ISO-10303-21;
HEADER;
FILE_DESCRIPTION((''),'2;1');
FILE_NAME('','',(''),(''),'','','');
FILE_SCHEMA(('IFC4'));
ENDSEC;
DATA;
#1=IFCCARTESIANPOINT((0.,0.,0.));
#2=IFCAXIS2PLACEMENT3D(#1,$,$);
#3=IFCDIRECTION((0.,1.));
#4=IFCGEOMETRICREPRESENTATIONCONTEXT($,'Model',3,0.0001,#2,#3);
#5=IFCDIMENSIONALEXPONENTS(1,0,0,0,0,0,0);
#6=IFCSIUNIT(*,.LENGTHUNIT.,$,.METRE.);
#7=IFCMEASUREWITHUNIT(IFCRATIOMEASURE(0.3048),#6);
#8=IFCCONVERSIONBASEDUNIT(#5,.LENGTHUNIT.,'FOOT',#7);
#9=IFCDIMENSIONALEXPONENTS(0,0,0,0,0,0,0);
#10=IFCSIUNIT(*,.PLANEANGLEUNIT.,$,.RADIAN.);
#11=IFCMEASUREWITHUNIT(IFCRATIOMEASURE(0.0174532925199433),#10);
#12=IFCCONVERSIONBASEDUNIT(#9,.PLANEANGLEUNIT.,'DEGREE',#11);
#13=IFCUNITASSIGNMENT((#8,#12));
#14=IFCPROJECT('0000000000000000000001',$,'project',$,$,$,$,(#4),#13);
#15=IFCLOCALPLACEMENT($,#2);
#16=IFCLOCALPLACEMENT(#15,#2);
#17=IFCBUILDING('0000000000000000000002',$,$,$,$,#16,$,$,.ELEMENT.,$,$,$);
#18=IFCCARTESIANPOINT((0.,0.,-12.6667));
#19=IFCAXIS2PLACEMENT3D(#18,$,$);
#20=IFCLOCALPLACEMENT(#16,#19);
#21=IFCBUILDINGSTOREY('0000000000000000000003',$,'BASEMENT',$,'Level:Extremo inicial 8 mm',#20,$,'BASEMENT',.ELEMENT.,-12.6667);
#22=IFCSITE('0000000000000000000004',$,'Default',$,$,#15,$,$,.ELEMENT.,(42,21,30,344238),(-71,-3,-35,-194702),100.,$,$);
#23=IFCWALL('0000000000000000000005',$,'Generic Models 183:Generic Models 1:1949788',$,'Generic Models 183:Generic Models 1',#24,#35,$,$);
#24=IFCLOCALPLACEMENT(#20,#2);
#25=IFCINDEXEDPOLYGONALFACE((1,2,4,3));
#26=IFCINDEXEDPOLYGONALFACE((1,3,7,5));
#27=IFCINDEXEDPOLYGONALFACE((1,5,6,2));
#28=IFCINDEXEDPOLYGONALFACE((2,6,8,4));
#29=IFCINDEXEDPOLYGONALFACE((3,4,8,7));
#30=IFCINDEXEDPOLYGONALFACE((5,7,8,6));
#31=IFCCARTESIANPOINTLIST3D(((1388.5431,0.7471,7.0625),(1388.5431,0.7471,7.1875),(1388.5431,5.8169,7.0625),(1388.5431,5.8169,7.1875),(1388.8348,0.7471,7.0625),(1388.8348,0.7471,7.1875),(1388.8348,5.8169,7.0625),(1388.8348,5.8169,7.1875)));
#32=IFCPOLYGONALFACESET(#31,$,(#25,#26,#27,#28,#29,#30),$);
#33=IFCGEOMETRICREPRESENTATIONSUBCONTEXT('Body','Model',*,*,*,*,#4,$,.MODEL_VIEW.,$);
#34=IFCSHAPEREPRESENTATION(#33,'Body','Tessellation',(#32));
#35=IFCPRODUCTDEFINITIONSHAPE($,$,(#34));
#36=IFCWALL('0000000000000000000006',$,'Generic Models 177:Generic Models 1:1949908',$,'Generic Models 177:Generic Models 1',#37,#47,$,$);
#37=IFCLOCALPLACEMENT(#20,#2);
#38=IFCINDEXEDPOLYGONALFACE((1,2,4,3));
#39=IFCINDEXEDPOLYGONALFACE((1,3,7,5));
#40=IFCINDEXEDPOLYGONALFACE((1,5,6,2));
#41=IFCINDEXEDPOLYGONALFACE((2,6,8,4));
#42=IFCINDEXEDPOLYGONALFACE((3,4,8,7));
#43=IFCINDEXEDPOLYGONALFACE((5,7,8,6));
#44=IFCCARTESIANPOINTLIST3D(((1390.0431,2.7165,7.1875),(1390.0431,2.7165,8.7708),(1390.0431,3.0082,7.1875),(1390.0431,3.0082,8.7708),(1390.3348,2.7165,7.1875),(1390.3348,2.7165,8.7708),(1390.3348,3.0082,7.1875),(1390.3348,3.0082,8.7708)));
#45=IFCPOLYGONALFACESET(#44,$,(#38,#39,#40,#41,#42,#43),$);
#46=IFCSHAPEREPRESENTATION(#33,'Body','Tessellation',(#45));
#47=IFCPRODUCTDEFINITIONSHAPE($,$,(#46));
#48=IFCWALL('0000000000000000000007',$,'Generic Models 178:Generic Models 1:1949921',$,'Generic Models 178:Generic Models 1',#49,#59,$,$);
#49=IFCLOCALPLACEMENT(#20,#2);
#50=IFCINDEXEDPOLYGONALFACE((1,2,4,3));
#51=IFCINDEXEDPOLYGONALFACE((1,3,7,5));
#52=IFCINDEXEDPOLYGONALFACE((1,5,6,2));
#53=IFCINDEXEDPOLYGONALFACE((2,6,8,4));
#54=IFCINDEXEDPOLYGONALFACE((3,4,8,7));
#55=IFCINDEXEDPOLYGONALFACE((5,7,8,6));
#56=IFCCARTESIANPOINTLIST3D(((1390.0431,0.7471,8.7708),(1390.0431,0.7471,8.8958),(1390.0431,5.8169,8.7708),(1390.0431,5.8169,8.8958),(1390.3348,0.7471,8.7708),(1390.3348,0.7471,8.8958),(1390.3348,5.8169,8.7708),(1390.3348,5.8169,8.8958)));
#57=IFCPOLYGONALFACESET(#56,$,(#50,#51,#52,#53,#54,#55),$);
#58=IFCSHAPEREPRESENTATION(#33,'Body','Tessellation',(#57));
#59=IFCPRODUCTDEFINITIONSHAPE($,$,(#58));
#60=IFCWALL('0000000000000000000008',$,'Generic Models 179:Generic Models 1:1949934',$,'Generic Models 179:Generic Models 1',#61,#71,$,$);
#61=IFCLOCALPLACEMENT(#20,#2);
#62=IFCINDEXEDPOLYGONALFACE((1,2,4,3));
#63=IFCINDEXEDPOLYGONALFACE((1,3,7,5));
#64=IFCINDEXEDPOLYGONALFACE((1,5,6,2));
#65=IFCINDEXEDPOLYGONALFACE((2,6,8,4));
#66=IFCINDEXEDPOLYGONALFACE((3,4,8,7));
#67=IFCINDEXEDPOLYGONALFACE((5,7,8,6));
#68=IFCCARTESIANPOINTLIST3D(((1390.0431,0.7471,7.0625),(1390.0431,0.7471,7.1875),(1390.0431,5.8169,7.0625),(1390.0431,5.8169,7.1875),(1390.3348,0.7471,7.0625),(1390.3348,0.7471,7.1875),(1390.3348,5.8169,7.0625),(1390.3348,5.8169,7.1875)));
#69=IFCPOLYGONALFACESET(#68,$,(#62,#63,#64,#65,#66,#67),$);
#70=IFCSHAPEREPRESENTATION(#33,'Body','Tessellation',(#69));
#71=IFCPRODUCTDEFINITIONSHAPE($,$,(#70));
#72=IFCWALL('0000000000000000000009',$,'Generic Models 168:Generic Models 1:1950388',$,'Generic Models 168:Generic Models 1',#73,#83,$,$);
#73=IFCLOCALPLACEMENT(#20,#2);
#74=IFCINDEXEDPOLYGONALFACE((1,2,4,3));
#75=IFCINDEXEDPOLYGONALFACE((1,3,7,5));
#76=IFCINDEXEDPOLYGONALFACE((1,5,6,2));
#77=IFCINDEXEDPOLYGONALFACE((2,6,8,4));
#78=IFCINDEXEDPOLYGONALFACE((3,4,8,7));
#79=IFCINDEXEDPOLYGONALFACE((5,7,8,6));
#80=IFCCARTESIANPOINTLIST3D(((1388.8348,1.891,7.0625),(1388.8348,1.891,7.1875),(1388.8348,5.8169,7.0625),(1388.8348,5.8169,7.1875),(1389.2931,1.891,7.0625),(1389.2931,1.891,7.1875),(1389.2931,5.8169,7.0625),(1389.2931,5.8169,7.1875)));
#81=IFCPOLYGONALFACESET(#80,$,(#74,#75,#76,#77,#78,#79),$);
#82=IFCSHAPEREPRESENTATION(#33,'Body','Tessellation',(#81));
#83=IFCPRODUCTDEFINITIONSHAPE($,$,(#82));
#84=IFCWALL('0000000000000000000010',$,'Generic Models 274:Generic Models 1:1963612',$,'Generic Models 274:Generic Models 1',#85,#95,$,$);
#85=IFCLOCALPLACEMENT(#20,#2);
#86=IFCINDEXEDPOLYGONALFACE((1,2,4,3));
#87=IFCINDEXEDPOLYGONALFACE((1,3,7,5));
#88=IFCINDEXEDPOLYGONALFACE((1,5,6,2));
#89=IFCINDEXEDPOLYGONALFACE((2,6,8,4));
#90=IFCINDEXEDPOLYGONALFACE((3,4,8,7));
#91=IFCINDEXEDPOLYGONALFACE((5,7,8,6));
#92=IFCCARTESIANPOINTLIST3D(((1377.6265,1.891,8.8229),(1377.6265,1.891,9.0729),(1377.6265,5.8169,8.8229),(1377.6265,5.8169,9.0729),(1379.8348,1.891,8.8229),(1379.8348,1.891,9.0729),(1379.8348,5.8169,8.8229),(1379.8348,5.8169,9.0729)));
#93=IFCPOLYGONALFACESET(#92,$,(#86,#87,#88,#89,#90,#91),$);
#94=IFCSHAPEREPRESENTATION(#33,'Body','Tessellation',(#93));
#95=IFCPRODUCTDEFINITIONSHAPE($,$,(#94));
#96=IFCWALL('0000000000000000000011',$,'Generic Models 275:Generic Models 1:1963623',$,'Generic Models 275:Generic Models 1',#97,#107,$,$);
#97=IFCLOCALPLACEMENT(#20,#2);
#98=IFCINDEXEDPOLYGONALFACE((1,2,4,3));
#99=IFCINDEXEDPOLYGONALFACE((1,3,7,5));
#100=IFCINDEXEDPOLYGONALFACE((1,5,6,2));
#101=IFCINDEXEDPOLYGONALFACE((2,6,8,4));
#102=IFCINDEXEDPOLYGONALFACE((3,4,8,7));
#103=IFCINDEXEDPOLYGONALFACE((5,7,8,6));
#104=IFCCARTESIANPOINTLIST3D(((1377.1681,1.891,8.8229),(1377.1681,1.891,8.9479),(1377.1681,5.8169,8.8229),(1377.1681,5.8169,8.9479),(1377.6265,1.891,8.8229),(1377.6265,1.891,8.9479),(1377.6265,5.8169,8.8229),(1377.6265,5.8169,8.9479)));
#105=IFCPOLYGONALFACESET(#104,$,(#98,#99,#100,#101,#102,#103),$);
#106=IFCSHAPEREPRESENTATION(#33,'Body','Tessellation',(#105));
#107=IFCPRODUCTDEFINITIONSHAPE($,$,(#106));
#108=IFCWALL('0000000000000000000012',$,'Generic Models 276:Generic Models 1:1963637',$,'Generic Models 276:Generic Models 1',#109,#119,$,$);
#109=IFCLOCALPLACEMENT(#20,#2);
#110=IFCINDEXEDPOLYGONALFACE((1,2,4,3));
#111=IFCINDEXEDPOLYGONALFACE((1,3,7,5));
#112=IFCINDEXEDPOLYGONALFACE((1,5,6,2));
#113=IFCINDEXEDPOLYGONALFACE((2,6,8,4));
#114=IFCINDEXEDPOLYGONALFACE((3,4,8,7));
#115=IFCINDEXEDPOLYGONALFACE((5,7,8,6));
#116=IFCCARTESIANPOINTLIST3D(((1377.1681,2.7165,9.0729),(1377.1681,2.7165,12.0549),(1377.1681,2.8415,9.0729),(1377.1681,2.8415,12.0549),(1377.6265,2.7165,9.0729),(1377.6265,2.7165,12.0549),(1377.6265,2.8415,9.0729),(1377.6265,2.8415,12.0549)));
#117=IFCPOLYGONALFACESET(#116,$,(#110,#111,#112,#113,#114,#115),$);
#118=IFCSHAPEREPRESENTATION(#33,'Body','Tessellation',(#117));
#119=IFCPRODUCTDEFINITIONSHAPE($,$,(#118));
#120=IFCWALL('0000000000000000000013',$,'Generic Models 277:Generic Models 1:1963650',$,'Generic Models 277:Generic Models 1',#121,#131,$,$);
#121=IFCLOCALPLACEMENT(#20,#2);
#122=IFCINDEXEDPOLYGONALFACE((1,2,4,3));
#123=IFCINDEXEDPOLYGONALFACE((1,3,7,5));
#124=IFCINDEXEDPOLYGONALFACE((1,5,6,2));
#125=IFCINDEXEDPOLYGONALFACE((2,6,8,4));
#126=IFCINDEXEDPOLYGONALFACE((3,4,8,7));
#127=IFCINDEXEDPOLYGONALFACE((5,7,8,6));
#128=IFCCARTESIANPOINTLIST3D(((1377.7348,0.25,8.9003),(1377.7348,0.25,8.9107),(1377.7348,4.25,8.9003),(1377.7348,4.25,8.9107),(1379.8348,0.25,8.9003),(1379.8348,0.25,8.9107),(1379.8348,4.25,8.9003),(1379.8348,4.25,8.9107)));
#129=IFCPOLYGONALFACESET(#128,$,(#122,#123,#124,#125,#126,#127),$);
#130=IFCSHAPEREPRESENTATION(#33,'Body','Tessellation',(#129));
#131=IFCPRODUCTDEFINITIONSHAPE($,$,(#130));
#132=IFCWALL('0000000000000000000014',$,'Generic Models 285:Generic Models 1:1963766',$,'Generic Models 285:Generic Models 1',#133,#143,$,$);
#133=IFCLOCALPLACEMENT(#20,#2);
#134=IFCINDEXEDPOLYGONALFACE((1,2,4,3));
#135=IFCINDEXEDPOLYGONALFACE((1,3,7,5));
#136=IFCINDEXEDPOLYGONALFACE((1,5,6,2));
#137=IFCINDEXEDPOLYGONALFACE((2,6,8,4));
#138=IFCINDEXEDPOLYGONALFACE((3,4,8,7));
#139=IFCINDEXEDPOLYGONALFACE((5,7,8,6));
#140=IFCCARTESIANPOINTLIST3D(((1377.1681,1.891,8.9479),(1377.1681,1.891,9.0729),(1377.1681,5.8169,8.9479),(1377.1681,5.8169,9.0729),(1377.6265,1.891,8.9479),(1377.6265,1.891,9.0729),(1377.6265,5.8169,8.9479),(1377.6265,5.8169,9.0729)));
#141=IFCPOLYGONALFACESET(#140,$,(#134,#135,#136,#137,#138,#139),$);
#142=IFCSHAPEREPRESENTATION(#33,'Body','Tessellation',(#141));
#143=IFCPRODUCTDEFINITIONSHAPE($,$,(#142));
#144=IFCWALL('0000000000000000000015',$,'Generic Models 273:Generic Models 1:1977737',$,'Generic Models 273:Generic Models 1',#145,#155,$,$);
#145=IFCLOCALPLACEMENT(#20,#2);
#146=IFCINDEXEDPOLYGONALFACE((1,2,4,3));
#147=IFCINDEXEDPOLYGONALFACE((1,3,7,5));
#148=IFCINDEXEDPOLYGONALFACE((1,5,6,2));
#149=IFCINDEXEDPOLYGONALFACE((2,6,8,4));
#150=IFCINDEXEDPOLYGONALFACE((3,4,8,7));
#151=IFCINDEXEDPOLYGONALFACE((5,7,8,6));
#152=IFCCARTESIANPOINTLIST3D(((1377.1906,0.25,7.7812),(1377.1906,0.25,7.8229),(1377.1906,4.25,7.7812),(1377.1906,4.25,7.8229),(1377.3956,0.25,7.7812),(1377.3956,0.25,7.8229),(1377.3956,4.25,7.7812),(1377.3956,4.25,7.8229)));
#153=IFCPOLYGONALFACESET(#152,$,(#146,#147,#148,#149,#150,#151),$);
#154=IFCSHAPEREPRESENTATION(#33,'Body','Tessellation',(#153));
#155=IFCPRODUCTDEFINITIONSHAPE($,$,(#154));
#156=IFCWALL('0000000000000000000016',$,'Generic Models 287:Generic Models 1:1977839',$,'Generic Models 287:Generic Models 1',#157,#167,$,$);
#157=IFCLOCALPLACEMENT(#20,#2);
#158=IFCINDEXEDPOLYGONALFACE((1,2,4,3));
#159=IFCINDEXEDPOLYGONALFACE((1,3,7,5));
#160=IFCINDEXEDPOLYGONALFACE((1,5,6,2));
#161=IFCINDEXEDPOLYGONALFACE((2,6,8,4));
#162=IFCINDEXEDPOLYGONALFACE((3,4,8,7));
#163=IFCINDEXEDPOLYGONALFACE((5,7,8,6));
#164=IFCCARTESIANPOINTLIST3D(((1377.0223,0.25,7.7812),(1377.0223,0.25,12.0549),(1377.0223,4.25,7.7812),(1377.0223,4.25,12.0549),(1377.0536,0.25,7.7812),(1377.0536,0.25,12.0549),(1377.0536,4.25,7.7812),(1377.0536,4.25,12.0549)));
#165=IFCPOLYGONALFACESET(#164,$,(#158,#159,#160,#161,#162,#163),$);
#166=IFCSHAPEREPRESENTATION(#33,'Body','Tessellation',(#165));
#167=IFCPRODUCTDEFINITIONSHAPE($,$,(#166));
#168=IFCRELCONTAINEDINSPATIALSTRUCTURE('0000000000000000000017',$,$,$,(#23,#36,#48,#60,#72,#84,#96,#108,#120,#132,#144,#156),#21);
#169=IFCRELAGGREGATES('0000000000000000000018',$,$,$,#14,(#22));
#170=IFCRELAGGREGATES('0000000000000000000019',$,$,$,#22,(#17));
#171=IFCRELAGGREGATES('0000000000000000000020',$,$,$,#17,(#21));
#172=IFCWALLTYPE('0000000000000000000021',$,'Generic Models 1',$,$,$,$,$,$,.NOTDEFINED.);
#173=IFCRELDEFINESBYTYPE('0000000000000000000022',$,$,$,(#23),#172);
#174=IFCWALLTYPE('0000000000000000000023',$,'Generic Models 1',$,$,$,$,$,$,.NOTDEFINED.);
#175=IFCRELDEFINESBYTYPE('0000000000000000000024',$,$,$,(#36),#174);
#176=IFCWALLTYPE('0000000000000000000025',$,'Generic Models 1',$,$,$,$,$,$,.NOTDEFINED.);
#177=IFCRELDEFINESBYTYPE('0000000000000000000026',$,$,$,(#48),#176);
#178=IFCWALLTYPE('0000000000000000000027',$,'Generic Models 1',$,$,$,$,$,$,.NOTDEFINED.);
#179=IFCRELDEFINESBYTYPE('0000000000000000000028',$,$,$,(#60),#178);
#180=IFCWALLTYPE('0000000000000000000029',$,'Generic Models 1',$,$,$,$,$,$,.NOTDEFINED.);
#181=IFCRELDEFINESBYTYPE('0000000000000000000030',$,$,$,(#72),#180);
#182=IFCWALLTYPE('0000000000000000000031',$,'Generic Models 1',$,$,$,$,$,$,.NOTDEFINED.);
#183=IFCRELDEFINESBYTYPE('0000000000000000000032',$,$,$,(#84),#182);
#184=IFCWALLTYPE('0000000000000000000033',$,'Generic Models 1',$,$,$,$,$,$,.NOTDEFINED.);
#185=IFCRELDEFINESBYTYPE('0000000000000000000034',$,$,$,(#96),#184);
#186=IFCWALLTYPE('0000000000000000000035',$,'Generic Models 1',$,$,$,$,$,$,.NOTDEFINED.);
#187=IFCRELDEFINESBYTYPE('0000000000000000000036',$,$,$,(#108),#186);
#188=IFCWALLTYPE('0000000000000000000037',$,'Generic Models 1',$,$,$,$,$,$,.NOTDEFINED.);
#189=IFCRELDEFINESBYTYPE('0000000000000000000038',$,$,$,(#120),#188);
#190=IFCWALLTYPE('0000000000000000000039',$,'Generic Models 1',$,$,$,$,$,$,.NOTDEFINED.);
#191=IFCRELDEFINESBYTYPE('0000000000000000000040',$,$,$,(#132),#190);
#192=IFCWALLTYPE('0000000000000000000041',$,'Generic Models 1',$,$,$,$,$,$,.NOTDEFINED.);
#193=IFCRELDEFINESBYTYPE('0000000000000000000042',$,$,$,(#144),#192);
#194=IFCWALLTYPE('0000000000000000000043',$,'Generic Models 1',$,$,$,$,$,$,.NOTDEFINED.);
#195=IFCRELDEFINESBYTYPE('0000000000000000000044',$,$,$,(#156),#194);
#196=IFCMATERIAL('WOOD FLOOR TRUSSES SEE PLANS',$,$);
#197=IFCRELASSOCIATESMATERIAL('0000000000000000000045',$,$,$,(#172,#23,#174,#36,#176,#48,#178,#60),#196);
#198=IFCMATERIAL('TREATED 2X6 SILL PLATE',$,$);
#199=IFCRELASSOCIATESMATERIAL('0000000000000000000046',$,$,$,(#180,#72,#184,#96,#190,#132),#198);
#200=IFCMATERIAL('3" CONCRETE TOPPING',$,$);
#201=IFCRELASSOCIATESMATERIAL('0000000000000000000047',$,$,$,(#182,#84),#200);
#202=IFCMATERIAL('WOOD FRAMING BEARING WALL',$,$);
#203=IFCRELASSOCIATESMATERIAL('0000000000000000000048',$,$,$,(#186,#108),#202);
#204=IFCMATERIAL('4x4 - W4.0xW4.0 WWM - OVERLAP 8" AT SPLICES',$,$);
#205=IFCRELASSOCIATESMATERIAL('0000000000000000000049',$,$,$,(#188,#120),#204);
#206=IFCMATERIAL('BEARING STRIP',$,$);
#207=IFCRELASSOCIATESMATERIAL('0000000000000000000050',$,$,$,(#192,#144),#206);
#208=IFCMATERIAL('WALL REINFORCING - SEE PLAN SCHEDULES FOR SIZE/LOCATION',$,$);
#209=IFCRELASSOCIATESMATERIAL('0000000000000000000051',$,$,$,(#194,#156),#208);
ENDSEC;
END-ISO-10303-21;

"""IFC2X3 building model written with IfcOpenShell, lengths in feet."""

from ifc_helpers import new_model, entity, si_unit, converted_unit, direction, frame, frame_2d, origin, place, context, subcontext, project, spatial, rectangle, extrude, material, type_object, element, save


model = new_model("IFC2X3")

# Units and contexts
model_context = context("Model", 3, precision=0.0001, world=origin(), true_north=direction((0.0, 1.0)))
body_context = subcontext(model_context, "Body", "Model", "MODEL_VIEW")
ifc_project = project(units=[converted_unit("LENGTHUNIT", "FOOT", entity("IfcRatioMeasure", 0.3048), si_unit("LENGTHUNIT", "METRE"), dimensions=[1, 0, 0, 0, 0, 0, 0]), converted_unit("PLANEANGLEUNIT", "DEGREE", entity("IfcRatioMeasure", 0.0174532925199433), si_unit("PLANEANGLEUNIT", "RADIAN"), dimensions=[0, 0, 0, 0, 0, 0, 0])], contexts=[model_context])

# Site, building, storey
site_placement = place(None, origin())
site = spatial("IfcSite", under=ifc_project, at=site_placement, Name="Default", CompositionType="ELEMENT", RefLatitude=(42, 21, 30, 344238), RefLongitude=(-71, -3, -35, -194702), RefElevation=100.0)
building_placement = place(site_placement, origin())
building = spatial("IfcBuilding", under=site, at=building_placement, CompositionType="ELEMENT")
storey_placement = place(building_placement, frame((0.0, 0.0, -12.6667)))
storey = spatial("IfcBuildingStorey", under=building, at=storey_placement, Name="BASEMENT", ObjectType="Level:Extremo inicial 8 mm", LongName="BASEMENT", CompositionType="ELEMENT", Elevation=-12.6667)

# Walls
ifc_material_1 = material(Name="BEARING STRIP")
ifc_material_2 = material(Name="WOOD FLOOR TRUSSES SEE PLANS")
ifc_material_3 = material(Name="3\" CONCRETE TOPPING")
ifc_material_4 = material(Name="4x4 - W4.0xW4.0 WWM - OVERLAP 8\" AT SPLICES")
wall_type_1 = type_object("IfcWallType", Name="Generic Models 1", PredefinedType="NOTDEFINED", material=ifc_material_2)
wall_1_placement = place(storey_placement, frame((1388.5431, 0.7471, 7.0625), z_axis=(0.0, 0.0, 1.0), x_axis=(0.0, 1.0, 0.0)))
element("IfcWall", 1, at=wall_1_placement, inside=storey, type_object=wall_type_1, material=ifc_material_2, Name="Generic Models 183:Generic Models 1:1949788", ObjectType="Generic Models 183:Generic Models 1", context=body_context, shape_type="SweptSolid", body=[
    extrude(rectangle(XDim=5.0697, YDim=0.2917, at=frame_2d((0.0, 0.0), x_axis=(1.0, 0.0))), frame((2.5349, -0.1458, 0.0)), (0.0, 0.0, 1.0), 0.125),
])
wall_type_2 = type_object("IfcWallType", Name="Generic Models 1", PredefinedType="NOTDEFINED", material=ifc_material_2)
wall_2_placement = place(storey_placement, frame((1390.0431, 2.7165, 7.1875)))
element("IfcWall", 2, at=wall_2_placement, inside=storey, type_object=wall_type_2, material=ifc_material_2, Name="Generic Models 177:Generic Models 1:1949908", ObjectType="Generic Models 177:Generic Models 1", context=body_context, shape_type="SweptSolid", body=[
    extrude(rectangle(XDim=0.2917, YDim=0.2917, at=frame_2d((0.0, 0.0), x_axis=(1.0, 0.0))), frame((0.1458, 0.1458, 0.0), z_axis=(0.0, 0.0, 1.0), x_axis=(0.0, 1.0, 0.0)), (0.0, 0.0, 1.0), 1.5833),
])
wall_type_3 = type_object("IfcWallType", Name="Generic Models 1", PredefinedType="NOTDEFINED", material=ifc_material_2)
wall_3_placement = place(storey_placement, frame((1390.0431, 0.7471, 8.7708), z_axis=(0.0, 0.0, 1.0), x_axis=(0.0, 1.0, 0.0)))
element("IfcWall", 3, at=wall_3_placement, inside=storey, type_object=wall_type_3, material=ifc_material_2, Name="Generic Models 178:Generic Models 1:1949921", ObjectType="Generic Models 178:Generic Models 1", context=body_context, shape_type="SweptSolid", body=[
    extrude(rectangle(XDim=5.0697, YDim=0.2917, at=frame_2d((0.0, 0.0), x_axis=(1.0, 0.0))), frame((2.5349, -0.1458, 0.0)), (0.0, 0.0, 1.0), 0.125),
])
wall_type_4 = type_object("IfcWallType", Name="Generic Models 1", PredefinedType="NOTDEFINED", material=ifc_material_2)
wall_4_placement = place(storey_placement, frame((1390.0431, 0.7471, 7.0625), z_axis=(0.0, 0.0, 1.0), x_axis=(0.0, 1.0, 0.0)))
element("IfcWall", 4, at=wall_4_placement, inside=storey, type_object=wall_type_4, material=ifc_material_2, Name="Generic Models 179:Generic Models 1:1949934", ObjectType="Generic Models 179:Generic Models 1", context=body_context, shape_type="SweptSolid", body=[
    extrude(rectangle(XDim=5.0697, YDim=0.2917, at=frame_2d((0.0, 0.0), x_axis=(1.0, 0.0))), frame((2.5349, -0.1458, 0.0)), (0.0, 0.0, 1.0), 0.125),
])
ifc_material_5 = material(Name="TREATED 2X6 SILL PLATE")
wall_type_5 = type_object("IfcWallType", Name="Generic Models 1", PredefinedType="NOTDEFINED", material=ifc_material_5)
wall_5_placement = place(storey_placement, frame((1388.8348, 1.891, 7.0625), z_axis=(0.0, 0.0, 1.0), x_axis=(0.0, 1.0, 0.0)))
element("IfcWall", 5, at=wall_5_placement, inside=storey, type_object=wall_type_5, material=ifc_material_5, Name="Generic Models 168:Generic Models 1:1950388", ObjectType="Generic Models 168:Generic Models 1", context=body_context, shape_type="SweptSolid", body=[
    extrude(rectangle(XDim=3.9258, YDim=0.4583, at=frame_2d((0.0, 0.0), x_axis=(1.0, 0.0))), frame((1.9629, -0.2292, 0.0)), (0.0, 0.0, 1.0), 0.125),
])
wall_type_6 = type_object("IfcWallType", Name="Generic Models 1", PredefinedType="NOTDEFINED", material=ifc_material_3)
wall_6_placement = place(storey_placement, frame((1377.6265, 1.891, 8.8229), z_axis=(0.0, 0.0, 1.0), x_axis=(0.0, 1.0, 0.0)))
element("IfcWall", 6, at=wall_6_placement, inside=storey, type_object=wall_type_6, material=ifc_material_3, Name="Generic Models 274:Generic Models 1:1963612", ObjectType="Generic Models 274:Generic Models 1", context=body_context, shape_type="SweptSolid", body=[
    extrude(rectangle(XDim=3.9258, YDim=2.2083, at=frame_2d((0.0, 0.0), x_axis=(1.0, 0.0))), frame((1.9629, -1.1042, 0.0)), (0.0, 0.0, 1.0), 0.25),
])
wall_type_7 = type_object("IfcWallType", Name="Generic Models 1", PredefinedType="NOTDEFINED", material=ifc_material_5)
wall_7_placement = place(storey_placement, frame((1377.1681, 1.891, 8.8229), z_axis=(0.0, 0.0, 1.0), x_axis=(0.0, 1.0, 0.0)))
element("IfcWall", 7, at=wall_7_placement, inside=storey, type_object=wall_type_7, material=ifc_material_5, Name="Generic Models 275:Generic Models 1:1963623", ObjectType="Generic Models 275:Generic Models 1", context=body_context, shape_type="SweptSolid", body=[
    extrude(rectangle(XDim=3.9258, YDim=0.4583, at=frame_2d((0.0, 0.0), x_axis=(1.0, 0.0))), frame((1.9629, -0.2292, 0.0)), (0.0, 0.0, 1.0), 0.125),
])
ifc_material_6 = material(Name="WOOD FRAMING BEARING WALL")
wall_type_8 = type_object("IfcWallType", Name="Generic Models 1", PredefinedType="NOTDEFINED", material=ifc_material_6)
wall_8_placement = place(storey_placement, frame((1377.1681, 2.7165, 9.0729)))
element("IfcWall", 8, at=wall_8_placement, inside=storey, type_object=wall_type_8, material=ifc_material_6, Name="Generic Models 276:Generic Models 1:1963637", ObjectType="Generic Models 276:Generic Models 1", context=body_context, shape_type="SweptSolid", body=[
    extrude(rectangle(XDim=0.125, YDim=0.4583, at=frame_2d((0.0, 0.0), x_axis=(1.0, 0.0))), frame((0.2292, 0.0625, 0.0), z_axis=(0.0, 0.0, 1.0), x_axis=(0.0, 1.0, 0.0)), (0.0, 0.0, 1.0), 2.982),
])
wall_type_9 = type_object("IfcWallType", Name="Generic Models 1", PredefinedType="NOTDEFINED", material=ifc_material_4)
wall_9_placement = place(storey_placement, frame((1377.7348, 0.25, 8.9003), z_axis=(0.0, 0.0, 1.0), x_axis=(0.0, 1.0, 0.0)))
element("IfcWall", 9, at=wall_9_placement, inside=storey, type_object=wall_type_9, material=ifc_material_4, Name="Generic Models 277:Generic Models 1:1963650", ObjectType="Generic Models 277:Generic Models 1", context=body_context, shape_type="SweptSolid", body=[
    extrude(rectangle(XDim=4.0, YDim=2.1, at=frame_2d((0.0, 0.0), x_axis=(1.0, 0.0))), frame((2.0, -1.05, 0.0)), (0.0, 0.0, 1.0), 0.0104),
])
wall_type_10 = type_object("IfcWallType", Name="Generic Models 1", PredefinedType="NOTDEFINED", material=ifc_material_5)
wall_10_placement = place(storey_placement, frame((1377.1681, 1.891, 8.9479), z_axis=(0.0, 0.0, 1.0), x_axis=(0.0, 1.0, 0.0)))
element("IfcWall", 10, at=wall_10_placement, inside=storey, type_object=wall_type_10, material=ifc_material_5, Name="Generic Models 285:Generic Models 1:1963766", ObjectType="Generic Models 285:Generic Models 1", context=body_context, shape_type="SweptSolid", body=[
    extrude(rectangle(XDim=3.9258, YDim=0.4583, at=frame_2d((0.0, 0.0), x_axis=(1.0, 0.0))), frame((1.9629, -0.2292, 0.0)), (0.0, 0.0, 1.0), 0.125),
])
wall_type_11 = type_object("IfcWallType", Name="Generic Models 1", PredefinedType="NOTDEFINED", material=ifc_material_1)
wall_11_placement = place(storey_placement, frame((1377.1906, 0.25, 7.7812), z_axis=(0.0, 0.0, 1.0), x_axis=(0.0, 1.0, 0.0)))
element("IfcWall", 11, at=wall_11_placement, inside=storey, type_object=wall_type_11, material=ifc_material_1, Name="Generic Models 273:Generic Models 1:1977737", ObjectType="Generic Models 273:Generic Models 1", context=body_context, shape_type="SweptSolid", body=[
    extrude(rectangle(XDim=4.0, YDim=0.205, at=frame_2d((0.0, 0.0), x_axis=(1.0, 0.0))), frame((2.0, -0.1025, 0.0)), (0.0, 0.0, 1.0), 0.0417),
])
ifc_material_7 = material(Name="WALL REINFORCING - SEE PLAN SCHEDULES FOR SIZE/LOCATION")
wall_type_12 = type_object("IfcWallType", Name="Generic Models 1", PredefinedType="NOTDEFINED", material=ifc_material_7)
wall_12_placement = place(storey_placement, frame((1377.0223, 0.25, 7.7812), z_axis=(0.0, 0.0, 1.0), x_axis=(0.0, 1.0, 0.0)))
element("IfcWall", 12, at=wall_12_placement, inside=storey, type_object=wall_type_12, material=ifc_material_7, Name="Generic Models 287:Generic Models 1:1977839", ObjectType="Generic Models 287:Generic Models 1", context=body_context, shape_type="SweptSolid", body=[
    extrude(rectangle(XDim=4.0, YDim=0.0312, at=frame_2d((0.0, 0.0), x_axis=(1.0, 0.0))), frame((2.0, -0.0156, 0.0)), (0.0, 0.0, 1.0), 4.2736),
])

save(model, "model.ifc")
